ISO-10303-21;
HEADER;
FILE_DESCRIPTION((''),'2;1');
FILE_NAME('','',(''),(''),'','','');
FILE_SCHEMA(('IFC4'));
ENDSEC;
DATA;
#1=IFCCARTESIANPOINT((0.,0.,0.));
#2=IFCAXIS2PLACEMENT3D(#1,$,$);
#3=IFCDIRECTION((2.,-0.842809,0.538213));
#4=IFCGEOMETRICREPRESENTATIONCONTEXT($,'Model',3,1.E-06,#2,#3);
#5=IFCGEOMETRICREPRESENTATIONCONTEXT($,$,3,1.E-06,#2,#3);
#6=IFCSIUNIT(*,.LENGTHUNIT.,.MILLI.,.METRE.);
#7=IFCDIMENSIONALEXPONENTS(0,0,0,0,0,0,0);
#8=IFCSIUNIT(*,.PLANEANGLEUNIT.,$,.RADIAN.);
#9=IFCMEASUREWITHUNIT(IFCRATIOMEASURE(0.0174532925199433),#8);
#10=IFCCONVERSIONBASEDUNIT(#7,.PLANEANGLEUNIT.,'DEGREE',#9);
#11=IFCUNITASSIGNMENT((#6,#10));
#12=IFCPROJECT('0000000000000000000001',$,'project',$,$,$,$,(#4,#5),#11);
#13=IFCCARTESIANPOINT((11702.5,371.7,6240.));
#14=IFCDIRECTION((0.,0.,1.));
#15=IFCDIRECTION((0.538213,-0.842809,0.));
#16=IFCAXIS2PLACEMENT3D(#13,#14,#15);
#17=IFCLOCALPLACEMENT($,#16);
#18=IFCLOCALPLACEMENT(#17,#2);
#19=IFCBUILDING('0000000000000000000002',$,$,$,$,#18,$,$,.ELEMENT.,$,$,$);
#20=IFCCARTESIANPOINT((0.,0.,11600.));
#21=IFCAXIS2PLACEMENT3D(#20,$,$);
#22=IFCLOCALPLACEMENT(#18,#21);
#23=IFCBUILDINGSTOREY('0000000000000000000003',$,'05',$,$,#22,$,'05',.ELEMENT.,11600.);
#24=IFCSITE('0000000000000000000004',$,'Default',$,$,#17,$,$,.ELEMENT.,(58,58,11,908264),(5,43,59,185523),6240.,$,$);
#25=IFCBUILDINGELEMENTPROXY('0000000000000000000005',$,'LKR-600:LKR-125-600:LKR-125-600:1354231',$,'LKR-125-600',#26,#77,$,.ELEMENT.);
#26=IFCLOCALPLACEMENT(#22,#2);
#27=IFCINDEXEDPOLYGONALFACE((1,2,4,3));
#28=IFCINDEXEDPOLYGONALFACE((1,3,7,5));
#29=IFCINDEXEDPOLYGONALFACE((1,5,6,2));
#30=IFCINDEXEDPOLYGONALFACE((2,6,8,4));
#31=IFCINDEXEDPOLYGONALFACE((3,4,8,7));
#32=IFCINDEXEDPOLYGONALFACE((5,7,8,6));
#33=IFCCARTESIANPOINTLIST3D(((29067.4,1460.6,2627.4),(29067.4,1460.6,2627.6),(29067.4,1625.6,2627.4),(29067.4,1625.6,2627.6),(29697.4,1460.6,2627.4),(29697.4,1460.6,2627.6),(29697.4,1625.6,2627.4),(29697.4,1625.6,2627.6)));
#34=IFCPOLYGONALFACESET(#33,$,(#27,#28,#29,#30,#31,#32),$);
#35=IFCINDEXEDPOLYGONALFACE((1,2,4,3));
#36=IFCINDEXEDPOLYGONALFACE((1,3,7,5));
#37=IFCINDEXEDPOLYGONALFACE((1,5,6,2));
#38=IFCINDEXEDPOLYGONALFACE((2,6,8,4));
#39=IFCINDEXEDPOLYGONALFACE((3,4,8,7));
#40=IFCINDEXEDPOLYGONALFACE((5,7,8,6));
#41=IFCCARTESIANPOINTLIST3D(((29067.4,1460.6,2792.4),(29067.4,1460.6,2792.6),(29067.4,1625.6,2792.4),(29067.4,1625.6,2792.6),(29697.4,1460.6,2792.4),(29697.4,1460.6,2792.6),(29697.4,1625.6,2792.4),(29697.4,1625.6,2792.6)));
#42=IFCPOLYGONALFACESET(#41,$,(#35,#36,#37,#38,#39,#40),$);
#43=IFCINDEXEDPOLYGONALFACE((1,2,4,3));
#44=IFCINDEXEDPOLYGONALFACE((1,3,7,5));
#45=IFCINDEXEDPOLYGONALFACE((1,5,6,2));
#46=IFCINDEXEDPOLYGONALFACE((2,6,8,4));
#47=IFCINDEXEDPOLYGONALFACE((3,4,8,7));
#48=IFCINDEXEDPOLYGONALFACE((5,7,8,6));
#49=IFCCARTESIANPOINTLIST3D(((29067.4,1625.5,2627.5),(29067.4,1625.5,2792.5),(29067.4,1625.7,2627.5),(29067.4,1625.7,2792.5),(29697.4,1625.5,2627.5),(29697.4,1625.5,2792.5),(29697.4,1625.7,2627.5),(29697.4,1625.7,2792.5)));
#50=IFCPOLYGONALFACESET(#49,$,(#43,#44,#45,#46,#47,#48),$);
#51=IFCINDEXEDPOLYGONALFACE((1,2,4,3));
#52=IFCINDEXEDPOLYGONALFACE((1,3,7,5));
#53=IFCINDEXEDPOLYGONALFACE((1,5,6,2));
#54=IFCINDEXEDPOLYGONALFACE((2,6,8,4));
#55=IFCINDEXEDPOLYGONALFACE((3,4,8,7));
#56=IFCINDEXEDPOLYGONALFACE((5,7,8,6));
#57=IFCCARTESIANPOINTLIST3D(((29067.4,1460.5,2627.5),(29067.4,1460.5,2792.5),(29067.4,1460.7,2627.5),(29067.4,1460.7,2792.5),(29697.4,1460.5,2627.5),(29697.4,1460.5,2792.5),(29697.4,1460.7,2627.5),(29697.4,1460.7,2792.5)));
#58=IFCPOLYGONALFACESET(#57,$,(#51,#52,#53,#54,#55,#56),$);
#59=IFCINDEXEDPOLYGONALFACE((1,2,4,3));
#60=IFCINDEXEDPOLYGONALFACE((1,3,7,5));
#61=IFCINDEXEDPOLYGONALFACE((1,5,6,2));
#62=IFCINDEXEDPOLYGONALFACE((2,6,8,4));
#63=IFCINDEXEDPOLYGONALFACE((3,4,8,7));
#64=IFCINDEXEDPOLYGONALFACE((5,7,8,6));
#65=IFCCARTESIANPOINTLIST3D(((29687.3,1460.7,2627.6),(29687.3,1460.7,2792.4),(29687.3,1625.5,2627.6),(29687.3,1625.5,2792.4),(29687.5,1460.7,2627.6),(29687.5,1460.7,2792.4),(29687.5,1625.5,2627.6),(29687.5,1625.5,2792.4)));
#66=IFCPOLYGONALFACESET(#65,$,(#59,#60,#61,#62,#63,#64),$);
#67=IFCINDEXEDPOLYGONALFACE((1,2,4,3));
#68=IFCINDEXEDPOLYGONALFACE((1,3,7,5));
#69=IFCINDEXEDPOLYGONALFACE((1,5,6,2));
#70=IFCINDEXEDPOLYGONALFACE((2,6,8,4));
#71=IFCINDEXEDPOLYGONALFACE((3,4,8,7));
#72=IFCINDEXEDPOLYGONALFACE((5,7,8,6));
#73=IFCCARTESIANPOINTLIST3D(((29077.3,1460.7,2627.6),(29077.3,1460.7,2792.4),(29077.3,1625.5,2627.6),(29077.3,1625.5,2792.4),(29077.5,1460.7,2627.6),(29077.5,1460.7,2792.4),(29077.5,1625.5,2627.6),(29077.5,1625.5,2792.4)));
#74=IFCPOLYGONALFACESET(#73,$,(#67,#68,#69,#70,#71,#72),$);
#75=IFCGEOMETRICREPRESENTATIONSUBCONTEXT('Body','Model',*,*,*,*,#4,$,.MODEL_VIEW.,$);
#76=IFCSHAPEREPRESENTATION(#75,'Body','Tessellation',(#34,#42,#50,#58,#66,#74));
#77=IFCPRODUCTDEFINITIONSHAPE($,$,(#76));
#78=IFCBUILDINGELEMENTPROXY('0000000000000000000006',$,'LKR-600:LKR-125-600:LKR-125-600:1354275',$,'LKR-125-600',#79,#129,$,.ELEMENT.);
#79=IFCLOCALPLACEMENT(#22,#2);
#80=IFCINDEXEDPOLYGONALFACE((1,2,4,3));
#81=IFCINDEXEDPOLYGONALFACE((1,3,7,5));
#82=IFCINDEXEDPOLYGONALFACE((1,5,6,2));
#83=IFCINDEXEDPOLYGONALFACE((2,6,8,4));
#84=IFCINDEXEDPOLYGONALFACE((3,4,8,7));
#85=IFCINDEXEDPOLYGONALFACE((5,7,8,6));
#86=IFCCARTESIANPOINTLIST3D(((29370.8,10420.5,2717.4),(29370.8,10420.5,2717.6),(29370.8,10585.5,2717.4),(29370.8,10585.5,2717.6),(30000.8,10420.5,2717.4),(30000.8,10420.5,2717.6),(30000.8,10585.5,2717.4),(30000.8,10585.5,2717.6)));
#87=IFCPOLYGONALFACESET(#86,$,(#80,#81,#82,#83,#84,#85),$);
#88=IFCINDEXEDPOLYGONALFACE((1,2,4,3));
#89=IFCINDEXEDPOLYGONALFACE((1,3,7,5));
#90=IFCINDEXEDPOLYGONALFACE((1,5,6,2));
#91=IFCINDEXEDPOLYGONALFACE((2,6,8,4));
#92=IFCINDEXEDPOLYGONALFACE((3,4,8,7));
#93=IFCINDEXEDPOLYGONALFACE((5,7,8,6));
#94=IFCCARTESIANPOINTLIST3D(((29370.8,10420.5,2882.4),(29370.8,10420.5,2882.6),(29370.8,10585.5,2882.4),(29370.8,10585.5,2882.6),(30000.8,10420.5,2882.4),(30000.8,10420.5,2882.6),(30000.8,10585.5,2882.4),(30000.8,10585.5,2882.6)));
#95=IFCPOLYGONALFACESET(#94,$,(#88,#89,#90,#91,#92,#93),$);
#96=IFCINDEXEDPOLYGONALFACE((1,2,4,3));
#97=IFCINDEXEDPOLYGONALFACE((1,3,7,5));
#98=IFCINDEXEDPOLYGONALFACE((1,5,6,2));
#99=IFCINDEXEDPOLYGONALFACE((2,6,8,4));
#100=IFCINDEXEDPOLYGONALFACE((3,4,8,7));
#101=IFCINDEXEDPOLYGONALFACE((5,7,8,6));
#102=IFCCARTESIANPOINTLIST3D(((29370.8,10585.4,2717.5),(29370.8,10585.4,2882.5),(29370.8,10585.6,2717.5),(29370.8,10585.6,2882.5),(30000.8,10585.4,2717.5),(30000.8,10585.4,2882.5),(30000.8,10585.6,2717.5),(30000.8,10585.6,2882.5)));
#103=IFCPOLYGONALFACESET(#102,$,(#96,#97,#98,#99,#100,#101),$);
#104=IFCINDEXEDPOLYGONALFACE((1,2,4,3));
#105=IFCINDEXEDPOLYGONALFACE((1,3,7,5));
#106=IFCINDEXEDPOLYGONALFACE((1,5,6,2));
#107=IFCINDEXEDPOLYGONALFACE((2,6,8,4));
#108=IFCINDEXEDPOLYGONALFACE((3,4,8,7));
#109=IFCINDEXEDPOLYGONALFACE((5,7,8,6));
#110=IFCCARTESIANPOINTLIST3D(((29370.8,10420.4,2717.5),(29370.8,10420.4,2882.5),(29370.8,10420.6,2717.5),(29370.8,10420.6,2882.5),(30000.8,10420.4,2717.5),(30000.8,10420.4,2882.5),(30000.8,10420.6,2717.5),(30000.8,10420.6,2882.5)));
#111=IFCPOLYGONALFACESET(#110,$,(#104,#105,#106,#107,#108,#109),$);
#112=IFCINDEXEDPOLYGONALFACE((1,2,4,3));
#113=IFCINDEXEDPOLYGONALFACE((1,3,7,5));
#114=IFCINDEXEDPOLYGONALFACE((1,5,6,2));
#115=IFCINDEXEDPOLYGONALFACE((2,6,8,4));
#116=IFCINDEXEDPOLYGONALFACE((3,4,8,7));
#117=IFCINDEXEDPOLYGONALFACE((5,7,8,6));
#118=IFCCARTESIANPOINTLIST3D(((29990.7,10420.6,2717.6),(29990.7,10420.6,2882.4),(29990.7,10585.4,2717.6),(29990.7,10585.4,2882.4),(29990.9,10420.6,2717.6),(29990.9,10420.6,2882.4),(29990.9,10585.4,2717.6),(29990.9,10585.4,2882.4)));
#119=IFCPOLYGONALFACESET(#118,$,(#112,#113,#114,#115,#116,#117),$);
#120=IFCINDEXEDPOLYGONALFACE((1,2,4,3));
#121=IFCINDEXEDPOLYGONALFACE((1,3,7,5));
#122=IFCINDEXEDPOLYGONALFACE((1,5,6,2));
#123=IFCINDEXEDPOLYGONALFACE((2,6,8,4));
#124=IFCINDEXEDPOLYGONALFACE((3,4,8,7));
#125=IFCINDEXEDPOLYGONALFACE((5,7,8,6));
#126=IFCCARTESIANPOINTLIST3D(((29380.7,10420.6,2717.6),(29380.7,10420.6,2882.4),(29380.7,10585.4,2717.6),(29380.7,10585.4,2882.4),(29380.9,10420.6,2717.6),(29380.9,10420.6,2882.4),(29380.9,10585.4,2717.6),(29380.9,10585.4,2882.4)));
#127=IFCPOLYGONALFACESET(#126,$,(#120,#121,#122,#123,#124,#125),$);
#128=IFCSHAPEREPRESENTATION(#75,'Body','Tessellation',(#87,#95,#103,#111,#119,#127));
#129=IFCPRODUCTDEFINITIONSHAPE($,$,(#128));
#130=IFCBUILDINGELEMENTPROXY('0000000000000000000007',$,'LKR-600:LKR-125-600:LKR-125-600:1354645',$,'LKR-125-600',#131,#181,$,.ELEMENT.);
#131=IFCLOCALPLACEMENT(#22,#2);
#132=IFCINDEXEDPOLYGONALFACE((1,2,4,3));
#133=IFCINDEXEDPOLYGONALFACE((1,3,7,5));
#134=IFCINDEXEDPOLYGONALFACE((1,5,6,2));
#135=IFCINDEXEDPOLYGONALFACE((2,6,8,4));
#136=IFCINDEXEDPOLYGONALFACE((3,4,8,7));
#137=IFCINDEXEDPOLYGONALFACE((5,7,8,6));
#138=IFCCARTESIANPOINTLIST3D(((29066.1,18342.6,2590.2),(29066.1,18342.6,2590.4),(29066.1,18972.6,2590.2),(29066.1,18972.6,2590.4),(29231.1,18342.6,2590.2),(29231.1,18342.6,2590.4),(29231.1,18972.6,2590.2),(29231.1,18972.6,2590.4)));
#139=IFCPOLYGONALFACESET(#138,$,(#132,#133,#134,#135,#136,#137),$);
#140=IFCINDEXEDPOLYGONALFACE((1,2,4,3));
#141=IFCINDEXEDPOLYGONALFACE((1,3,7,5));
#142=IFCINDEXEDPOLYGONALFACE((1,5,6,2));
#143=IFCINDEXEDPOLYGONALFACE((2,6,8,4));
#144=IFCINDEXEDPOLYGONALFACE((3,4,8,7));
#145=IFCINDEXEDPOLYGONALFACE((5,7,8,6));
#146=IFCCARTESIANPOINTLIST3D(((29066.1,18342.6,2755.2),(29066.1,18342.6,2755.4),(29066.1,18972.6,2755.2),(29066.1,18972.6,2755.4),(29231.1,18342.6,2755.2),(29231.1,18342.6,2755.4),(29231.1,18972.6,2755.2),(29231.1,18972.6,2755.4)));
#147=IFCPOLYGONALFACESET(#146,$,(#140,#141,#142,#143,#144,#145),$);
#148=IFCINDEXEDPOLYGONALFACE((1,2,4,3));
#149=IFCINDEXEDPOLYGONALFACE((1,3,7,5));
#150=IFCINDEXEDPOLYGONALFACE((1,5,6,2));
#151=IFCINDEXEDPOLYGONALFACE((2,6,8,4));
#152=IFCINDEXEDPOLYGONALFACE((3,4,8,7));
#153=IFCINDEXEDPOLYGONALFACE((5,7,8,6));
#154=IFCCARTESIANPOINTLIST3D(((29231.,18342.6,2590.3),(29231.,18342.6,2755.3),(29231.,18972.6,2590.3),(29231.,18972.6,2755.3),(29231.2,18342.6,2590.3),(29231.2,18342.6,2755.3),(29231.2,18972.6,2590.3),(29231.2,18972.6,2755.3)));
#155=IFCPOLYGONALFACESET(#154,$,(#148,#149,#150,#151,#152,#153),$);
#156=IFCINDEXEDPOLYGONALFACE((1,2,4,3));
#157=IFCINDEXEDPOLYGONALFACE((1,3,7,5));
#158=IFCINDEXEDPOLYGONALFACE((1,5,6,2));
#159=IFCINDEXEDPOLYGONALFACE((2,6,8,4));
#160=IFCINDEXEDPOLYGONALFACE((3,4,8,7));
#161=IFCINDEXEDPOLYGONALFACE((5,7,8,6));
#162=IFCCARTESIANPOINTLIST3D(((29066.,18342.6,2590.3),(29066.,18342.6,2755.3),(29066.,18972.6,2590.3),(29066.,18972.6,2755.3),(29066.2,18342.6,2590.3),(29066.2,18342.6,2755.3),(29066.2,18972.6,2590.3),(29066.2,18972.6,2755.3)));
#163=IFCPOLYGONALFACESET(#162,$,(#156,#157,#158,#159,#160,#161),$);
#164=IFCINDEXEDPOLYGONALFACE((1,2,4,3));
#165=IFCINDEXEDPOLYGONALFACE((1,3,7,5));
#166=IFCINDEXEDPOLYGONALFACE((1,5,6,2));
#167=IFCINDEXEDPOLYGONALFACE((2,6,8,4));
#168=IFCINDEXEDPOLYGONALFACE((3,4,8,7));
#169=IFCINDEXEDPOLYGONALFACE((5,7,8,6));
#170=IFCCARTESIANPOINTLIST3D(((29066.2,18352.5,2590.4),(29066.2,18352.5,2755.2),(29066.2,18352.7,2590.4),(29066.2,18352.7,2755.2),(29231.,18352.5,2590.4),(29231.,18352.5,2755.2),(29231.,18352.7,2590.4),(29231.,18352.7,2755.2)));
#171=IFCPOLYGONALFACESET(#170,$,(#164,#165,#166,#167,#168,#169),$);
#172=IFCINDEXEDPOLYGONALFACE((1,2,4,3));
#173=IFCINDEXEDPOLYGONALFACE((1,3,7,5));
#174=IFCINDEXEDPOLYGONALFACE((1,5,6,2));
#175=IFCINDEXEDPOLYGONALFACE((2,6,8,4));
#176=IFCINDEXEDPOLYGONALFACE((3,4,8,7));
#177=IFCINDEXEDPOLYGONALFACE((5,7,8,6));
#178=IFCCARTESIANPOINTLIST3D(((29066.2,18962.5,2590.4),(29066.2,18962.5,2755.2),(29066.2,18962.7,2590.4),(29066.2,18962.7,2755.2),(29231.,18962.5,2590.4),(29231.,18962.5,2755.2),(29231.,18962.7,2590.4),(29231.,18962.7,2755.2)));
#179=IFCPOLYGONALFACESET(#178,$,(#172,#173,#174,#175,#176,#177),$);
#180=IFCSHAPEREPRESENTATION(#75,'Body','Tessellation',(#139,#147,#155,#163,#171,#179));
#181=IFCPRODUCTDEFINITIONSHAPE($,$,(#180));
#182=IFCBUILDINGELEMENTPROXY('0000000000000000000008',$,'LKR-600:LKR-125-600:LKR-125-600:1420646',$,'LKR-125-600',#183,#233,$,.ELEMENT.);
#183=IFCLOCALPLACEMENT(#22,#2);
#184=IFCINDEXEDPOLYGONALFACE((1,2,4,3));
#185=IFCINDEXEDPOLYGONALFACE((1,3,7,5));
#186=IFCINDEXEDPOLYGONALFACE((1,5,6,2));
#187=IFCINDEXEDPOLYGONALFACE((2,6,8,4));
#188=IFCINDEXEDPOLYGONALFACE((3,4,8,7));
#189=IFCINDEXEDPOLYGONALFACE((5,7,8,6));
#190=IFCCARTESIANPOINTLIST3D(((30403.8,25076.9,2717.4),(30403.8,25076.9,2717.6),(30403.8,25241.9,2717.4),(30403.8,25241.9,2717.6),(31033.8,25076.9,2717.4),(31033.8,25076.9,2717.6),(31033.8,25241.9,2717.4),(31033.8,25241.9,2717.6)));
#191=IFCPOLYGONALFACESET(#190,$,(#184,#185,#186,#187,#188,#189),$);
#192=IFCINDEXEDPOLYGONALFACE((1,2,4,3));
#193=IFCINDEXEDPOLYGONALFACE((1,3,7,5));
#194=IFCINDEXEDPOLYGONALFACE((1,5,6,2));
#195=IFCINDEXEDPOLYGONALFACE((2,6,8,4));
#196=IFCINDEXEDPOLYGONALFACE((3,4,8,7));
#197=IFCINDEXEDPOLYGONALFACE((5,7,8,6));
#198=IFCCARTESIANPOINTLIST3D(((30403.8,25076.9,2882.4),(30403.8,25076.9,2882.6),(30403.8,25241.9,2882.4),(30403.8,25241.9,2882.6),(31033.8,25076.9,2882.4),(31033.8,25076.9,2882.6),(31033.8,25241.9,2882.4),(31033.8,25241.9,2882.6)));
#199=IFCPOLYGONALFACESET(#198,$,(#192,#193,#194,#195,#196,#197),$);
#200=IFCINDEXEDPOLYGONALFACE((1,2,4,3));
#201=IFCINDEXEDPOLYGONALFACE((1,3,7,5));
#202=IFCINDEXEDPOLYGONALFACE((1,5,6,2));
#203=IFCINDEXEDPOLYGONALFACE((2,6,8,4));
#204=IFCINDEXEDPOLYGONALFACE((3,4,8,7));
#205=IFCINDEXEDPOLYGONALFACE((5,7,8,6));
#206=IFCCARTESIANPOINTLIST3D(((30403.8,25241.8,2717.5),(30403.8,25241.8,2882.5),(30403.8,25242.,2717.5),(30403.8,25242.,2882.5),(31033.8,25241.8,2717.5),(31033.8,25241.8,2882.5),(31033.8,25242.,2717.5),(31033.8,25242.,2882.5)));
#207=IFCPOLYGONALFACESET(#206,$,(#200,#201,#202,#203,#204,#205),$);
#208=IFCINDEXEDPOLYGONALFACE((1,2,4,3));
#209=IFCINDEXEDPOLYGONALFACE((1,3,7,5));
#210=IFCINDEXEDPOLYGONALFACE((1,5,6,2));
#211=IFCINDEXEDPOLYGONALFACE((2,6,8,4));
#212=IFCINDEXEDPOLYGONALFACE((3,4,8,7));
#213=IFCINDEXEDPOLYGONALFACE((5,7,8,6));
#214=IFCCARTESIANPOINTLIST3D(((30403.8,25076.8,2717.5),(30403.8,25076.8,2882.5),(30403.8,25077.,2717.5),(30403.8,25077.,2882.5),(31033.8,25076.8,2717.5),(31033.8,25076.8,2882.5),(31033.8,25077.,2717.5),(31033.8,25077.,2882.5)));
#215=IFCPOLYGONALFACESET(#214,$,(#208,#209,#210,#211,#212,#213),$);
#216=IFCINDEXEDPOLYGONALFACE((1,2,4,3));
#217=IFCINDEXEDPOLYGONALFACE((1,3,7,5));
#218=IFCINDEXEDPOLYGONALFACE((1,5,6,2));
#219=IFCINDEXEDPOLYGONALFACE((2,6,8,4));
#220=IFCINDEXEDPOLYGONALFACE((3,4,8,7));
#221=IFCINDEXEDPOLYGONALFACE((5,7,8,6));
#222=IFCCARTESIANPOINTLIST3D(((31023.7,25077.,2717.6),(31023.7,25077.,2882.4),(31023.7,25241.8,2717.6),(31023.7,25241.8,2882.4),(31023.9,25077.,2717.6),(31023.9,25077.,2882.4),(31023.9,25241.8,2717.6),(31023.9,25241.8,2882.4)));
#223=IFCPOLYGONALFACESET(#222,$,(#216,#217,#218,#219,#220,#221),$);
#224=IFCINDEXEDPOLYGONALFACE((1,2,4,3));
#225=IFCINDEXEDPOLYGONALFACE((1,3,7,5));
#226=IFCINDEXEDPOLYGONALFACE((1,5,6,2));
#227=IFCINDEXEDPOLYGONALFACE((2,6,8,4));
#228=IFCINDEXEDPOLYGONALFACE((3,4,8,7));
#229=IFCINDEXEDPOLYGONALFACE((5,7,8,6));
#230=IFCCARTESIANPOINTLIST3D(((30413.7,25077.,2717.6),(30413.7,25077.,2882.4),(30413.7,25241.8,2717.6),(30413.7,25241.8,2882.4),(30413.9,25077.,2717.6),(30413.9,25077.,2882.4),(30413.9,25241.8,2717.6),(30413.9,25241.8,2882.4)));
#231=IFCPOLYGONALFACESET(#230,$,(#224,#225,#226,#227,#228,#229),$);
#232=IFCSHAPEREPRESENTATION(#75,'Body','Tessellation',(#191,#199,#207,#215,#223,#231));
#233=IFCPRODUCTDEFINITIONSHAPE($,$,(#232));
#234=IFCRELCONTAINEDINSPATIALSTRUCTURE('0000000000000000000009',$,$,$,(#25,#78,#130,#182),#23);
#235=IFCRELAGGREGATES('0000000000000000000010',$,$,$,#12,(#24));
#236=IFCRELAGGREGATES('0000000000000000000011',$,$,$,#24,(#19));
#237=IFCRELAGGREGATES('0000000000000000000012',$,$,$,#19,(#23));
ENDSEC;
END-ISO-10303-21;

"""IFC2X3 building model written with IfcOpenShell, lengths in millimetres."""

from ifc_helpers import new_model, entity, si_unit, converted_unit, direction, frame, frame_2d, origin, place, context, subcontext, project, spatial, rectangle, extrude, source, transform, mapped, element, save


model = new_model("IFC2X3")

# Units and contexts
model_context = context("Model", 3, precision=1e-06, world=origin(), true_north=direction((2.0, -0.842809, 0.538213)))
context_of_model = context(None, 3, precision=1e-06, world=origin(), true_north=direction((2.0, -0.842809, 0.538213)))
body_context = subcontext(model_context, "Body", "Model", "MODEL_VIEW")
ifc_project = project(units=[si_unit("LENGTHUNIT", "METRE", prefix="MILLI"), converted_unit("PLANEANGLEUNIT", "DEGREE", entity("IfcRatioMeasure", 0.0174532925199433), si_unit("PLANEANGLEUNIT", "RADIAN"), dimensions=[0, 0, 0, 0, 0, 0, 0])], contexts=[model_context, context_of_model])

# Site, building, storey
site_placement = place(None, frame((11702.5, 371.7, 6240.0), z_axis=(0.0, 0.0, 1.0), x_axis=(0.538213, -0.842809, 0.0)))
site = spatial("IfcSite", under=ifc_project, at=site_placement, Name="Default", CompositionType="ELEMENT", RefLatitude=(58, 58, 11, 908264), RefLongitude=(5, 43, 59, 185523), RefElevation=6240.0)
building_placement = place(site_placement, origin())
building = spatial("IfcBuilding", under=site, at=building_placement, CompositionType="ELEMENT")
storey_placement = place(building_placement, frame((0.0, 0.0, 11600.0)))
storey = spatial("IfcBuildingStorey", under=building, at=storey_placement, Name="05", LongName="05", CompositionType="ELEMENT", Elevation=11600.0)

# Building element proxies
shared_shape_1 = source(origin(), body_context, "Body", "SweptSolid", [
    extrude(rectangle(XDim=165.0, YDim=630.0, at=frame_2d((0.0, 0.0), x_axis=(1.0, 0.0))), frame((0.0, 0.0, -82.6), z_axis=(0.0, 0.0, 1.0), x_axis=(0.0, -1.0, 0.0)), (0.0, 0.0, 1.0), 0.2),
    extrude(rectangle(XDim=165.0, YDim=630.0, at=frame_2d((0.0, 0.0), x_axis=(1.0, 0.0))), frame((0.0, 0.0, 82.4), z_axis=(0.0, 0.0, 1.0), x_axis=(0.0, -1.0, 0.0)), (0.0, 0.0, 1.0), 0.2),
    extrude(rectangle(XDim=0.2, YDim=630.0, at=frame_2d((0.0, 0.0), x_axis=(1.0, 0.0))), frame((0.0, 82.5, -82.5), z_axis=(0.0, 0.0, 1.0), x_axis=(0.0, 1.0, 0.0)), (0.0, 0.0, 1.0), 165.0),
    extrude(rectangle(XDim=0.2, YDim=630.0, at=frame_2d((0.0, 0.0), x_axis=(1.0, 0.0))), frame((0.0, -82.5, -82.5), z_axis=(0.0, 0.0, 1.0), x_axis=(0.0, 1.0, 0.0)), (0.0, 0.0, 1.0), 165.0),
    extrude(rectangle(XDim=0.2, YDim=164.8, at=frame_2d((0.0, 0.0), x_axis=(1.0, 0.0))), frame((305.0, 0.0, -82.4)), (0.0, 0.0, 1.0), 164.8),
    extrude(rectangle(XDim=0.2, YDim=164.8, at=frame_2d((0.0, 0.0), x_axis=(1.0, 0.0))), frame((-305.0, 0.0, -82.4)), (0.0, 0.0, 1.0), 164.8),
])
for number, where, name in (
    (1, (29382.4, 1543.1, 2710.0), "LKR-600:LKR-125-600:LKR-125-600:1354231"),
    (2, (29685.8, 10503.0, 2800.0), "LKR-600:LKR-125-600:LKR-125-600:1354275"),
):
    element("IfcBuildingElementProxy", number, at=place(storey_placement, frame(where)), inside=storey, Name=name, ObjectType="LKR-125-600", CompositionType="ELEMENT", context=body_context, shape_type="MappedRepresentation", body=[
        mapped(shared_shape_1, transform((0.0, 0.0, 0.0), scale=1.0)),
    ])
proxy_1_placement = place(storey_placement, frame((29148.6, 18657.6, 2672.8), z_axis=(0.0, 0.0, 1.0), x_axis=(0.0, -1.0, 0.0)))
element("IfcBuildingElementProxy", 3, at=proxy_1_placement, inside=storey, Name="LKR-600:LKR-125-600:LKR-125-600:1354645", ObjectType="LKR-125-600", CompositionType="ELEMENT", context=body_context, shape_type="MappedRepresentation", body=[
    mapped(shared_shape_1, transform((0.0, 0.0, 0.0), scale=1.0)),
])
proxy_2_placement = place(storey_placement, frame((30718.8, 25159.4, 2800.0)))
element("IfcBuildingElementProxy", 4, at=proxy_2_placement, inside=storey, Name="LKR-600:LKR-125-600:LKR-125-600:1420646", ObjectType="LKR-125-600", CompositionType="ELEMENT", context=body_context, shape_type="MappedRepresentation", body=[
    mapped(shared_shape_1, transform((0.0, 0.0, 0.0), scale=1.0)),
])

save(model, "model.ifc")
